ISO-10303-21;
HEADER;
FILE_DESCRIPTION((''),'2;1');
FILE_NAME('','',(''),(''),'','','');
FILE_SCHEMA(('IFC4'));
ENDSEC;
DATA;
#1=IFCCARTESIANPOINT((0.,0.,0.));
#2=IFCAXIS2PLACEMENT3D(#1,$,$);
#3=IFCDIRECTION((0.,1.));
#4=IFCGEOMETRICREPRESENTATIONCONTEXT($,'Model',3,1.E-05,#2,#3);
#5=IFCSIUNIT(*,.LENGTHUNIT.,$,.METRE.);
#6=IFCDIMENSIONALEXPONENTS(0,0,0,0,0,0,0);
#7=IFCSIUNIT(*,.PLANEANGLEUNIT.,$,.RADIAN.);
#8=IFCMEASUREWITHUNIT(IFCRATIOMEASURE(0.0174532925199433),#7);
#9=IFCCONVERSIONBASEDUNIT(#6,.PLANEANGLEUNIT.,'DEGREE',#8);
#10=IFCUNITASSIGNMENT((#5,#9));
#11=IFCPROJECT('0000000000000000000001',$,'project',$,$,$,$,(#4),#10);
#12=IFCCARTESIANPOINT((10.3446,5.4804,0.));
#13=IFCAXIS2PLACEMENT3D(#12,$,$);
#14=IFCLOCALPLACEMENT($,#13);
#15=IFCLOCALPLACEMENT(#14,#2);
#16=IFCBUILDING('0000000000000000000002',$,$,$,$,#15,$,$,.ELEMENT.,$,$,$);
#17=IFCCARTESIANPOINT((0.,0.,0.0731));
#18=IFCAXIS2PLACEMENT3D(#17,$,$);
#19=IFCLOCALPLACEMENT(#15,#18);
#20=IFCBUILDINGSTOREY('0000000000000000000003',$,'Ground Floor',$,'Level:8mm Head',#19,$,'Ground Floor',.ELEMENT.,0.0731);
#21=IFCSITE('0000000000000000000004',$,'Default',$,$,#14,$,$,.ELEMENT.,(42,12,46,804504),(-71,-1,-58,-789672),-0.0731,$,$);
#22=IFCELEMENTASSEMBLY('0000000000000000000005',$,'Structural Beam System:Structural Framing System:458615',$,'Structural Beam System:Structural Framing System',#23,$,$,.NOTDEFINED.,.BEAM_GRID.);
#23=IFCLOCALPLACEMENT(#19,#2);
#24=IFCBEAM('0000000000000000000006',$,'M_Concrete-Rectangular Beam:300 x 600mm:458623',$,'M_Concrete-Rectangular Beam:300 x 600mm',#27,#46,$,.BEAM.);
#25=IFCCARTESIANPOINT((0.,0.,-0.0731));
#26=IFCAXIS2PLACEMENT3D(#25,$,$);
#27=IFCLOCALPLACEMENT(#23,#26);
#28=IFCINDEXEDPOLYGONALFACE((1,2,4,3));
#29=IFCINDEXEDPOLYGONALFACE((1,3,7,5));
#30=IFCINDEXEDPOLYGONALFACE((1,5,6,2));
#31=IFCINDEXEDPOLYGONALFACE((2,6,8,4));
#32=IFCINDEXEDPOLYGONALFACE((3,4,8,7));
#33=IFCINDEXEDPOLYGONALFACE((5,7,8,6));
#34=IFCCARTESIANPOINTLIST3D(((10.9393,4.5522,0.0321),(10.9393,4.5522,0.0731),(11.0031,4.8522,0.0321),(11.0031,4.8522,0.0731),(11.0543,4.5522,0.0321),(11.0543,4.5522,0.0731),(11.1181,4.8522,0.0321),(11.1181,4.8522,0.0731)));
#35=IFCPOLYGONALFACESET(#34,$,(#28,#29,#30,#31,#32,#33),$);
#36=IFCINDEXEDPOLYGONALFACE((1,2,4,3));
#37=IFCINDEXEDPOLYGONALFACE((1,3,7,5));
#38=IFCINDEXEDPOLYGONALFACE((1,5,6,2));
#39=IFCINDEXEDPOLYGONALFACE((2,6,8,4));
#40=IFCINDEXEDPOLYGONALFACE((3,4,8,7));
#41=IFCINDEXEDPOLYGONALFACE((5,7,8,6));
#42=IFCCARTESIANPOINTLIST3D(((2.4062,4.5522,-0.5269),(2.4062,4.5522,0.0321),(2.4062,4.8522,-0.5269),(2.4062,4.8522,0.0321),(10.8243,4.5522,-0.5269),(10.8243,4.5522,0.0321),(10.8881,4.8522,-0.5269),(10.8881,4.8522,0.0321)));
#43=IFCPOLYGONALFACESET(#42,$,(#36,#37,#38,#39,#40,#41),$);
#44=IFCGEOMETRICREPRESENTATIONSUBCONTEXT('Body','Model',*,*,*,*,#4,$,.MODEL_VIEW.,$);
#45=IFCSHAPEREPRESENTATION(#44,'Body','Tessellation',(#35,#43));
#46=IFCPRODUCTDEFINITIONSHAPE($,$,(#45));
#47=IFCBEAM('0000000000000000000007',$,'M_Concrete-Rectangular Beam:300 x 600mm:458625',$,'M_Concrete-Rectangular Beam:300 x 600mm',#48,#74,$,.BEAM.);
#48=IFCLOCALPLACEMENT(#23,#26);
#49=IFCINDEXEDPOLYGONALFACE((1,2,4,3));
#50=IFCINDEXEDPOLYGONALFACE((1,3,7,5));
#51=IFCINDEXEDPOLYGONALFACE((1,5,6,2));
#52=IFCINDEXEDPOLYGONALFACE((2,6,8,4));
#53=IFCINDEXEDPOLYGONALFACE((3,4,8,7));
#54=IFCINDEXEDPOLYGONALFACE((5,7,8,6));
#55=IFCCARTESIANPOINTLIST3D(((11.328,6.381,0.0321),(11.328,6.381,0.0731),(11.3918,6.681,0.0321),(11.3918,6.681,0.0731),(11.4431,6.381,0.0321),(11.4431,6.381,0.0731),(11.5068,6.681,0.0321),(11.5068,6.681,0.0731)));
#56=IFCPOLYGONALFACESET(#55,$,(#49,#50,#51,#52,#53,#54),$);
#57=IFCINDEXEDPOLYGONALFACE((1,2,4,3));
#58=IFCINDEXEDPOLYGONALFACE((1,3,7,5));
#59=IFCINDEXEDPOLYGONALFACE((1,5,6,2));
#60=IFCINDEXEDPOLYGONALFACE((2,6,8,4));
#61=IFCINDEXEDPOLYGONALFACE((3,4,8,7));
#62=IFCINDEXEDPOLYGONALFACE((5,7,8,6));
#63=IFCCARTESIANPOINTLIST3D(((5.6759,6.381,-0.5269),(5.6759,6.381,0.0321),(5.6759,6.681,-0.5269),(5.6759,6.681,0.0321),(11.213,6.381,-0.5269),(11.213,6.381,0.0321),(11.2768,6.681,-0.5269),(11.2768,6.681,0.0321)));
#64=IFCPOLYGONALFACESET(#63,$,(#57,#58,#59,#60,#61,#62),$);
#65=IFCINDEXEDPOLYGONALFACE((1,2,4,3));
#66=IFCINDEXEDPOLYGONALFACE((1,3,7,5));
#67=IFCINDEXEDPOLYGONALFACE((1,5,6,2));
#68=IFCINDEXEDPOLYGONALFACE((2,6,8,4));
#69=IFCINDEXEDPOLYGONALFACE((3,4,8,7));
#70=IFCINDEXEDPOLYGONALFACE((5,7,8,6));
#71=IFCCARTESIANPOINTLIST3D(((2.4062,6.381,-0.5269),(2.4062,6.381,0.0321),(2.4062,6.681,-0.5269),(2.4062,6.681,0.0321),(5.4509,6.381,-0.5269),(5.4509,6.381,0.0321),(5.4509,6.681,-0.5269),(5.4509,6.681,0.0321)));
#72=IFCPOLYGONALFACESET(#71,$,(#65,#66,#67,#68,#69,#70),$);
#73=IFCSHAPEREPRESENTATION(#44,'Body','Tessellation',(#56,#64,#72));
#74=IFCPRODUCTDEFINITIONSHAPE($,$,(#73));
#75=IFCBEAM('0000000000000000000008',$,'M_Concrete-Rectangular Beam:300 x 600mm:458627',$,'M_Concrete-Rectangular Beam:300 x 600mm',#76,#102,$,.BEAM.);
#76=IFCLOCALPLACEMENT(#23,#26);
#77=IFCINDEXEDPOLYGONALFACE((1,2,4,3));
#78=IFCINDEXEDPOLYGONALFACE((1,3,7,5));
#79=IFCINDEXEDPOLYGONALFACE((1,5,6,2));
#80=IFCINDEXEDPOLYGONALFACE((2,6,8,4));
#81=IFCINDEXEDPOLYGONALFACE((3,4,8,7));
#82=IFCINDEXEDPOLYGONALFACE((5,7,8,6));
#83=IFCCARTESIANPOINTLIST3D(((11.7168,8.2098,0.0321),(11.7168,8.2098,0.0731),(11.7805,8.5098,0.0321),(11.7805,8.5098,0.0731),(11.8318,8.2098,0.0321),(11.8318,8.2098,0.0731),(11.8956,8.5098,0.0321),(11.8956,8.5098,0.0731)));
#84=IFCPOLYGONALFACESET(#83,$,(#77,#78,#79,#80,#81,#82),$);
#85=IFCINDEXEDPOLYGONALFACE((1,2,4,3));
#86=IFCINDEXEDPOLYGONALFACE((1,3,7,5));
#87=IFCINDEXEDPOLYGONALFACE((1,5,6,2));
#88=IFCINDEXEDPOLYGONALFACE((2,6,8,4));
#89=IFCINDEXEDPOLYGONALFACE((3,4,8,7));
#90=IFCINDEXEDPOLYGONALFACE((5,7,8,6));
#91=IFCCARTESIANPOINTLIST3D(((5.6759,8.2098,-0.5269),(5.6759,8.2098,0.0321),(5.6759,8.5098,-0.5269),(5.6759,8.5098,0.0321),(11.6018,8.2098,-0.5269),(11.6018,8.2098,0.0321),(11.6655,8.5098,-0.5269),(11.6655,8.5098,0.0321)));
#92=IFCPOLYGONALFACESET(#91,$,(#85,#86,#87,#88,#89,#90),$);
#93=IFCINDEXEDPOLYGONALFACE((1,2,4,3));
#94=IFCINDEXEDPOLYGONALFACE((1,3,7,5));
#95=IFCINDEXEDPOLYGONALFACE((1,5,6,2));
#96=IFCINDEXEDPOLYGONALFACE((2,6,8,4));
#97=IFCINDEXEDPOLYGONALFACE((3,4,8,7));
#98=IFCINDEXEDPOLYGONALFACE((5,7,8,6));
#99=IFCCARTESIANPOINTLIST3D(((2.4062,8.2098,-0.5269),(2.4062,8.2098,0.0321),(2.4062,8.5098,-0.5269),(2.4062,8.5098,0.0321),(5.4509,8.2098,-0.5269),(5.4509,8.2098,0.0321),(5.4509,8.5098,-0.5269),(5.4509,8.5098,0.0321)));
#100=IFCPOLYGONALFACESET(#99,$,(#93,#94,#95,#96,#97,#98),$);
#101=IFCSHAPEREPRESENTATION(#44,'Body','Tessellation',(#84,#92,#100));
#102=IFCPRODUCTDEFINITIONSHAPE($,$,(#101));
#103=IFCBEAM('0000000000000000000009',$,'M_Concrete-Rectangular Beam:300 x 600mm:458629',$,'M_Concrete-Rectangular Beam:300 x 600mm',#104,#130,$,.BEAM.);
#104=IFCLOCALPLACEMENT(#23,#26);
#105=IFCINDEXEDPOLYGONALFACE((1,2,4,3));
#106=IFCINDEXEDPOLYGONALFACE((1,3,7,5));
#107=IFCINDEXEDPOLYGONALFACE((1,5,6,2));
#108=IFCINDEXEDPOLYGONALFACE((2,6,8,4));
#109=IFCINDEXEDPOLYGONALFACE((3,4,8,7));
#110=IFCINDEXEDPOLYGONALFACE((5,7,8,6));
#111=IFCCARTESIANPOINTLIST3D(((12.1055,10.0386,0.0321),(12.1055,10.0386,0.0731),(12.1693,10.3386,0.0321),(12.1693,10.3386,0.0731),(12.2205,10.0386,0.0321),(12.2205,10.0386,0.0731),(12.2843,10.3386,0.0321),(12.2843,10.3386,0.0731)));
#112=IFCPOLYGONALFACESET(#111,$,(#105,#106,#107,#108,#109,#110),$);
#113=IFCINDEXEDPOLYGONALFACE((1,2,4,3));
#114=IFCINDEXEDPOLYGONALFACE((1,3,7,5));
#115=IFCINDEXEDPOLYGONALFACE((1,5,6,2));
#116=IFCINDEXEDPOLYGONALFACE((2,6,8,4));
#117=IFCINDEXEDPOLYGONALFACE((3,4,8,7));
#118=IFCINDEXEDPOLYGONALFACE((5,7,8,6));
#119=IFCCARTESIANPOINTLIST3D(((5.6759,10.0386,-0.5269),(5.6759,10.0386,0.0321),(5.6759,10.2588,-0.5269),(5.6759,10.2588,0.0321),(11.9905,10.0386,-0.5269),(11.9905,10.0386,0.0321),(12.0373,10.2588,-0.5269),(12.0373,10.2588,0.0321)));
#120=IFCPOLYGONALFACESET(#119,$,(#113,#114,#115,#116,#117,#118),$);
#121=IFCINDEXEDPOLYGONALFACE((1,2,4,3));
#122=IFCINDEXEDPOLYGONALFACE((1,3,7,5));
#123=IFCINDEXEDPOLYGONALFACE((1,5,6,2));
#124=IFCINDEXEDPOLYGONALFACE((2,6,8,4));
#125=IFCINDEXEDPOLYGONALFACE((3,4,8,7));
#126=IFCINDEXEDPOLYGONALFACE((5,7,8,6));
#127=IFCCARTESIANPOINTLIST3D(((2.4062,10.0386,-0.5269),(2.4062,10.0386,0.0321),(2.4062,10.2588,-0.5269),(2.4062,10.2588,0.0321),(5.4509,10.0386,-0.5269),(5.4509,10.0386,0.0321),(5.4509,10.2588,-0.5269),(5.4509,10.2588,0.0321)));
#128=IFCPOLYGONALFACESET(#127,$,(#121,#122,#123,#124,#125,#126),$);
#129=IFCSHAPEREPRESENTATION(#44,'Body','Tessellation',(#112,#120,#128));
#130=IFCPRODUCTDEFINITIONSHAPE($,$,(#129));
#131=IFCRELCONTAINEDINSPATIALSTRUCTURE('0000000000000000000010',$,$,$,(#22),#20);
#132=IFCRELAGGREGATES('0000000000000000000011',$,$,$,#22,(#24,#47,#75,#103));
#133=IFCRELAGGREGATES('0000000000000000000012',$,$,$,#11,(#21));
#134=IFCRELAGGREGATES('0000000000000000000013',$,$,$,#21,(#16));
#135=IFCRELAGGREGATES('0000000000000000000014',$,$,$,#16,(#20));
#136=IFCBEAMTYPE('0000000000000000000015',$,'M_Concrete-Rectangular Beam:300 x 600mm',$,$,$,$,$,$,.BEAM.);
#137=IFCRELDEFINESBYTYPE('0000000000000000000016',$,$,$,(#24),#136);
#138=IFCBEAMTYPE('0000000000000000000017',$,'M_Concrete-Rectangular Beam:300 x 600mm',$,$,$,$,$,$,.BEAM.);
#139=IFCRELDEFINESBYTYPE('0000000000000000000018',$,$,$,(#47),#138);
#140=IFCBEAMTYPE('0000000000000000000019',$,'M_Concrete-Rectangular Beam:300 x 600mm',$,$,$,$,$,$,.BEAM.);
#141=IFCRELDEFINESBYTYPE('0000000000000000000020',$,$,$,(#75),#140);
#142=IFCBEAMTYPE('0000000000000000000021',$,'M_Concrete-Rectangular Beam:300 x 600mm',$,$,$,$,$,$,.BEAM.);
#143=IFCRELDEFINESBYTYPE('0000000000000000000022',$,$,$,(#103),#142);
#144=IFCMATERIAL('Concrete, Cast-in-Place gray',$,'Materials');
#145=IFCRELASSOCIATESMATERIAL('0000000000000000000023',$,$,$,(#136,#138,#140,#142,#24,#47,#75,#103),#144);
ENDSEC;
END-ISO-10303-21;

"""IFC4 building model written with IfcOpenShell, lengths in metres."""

from ifc_helpers import new_model, entity, si_unit, converted_unit, direction, frame, frame_2d, origin, place, context, subcontext, project, spatial, rectangle, extrude, clip, halfspace, source, transform, mapped, material, material_profile, profile_set, profile_usage, type_object, type_shapes, element, aggregate, save


model = new_model("IFC4")

# Units and contexts
model_context = context("Model", 3, precision=1e-05, world=origin(), true_north=direction((0.0, 1.0)))
body_context = subcontext(model_context, "Body", "Model", "MODEL_VIEW")
ifc_project = project(units=[si_unit("LENGTHUNIT", "METRE"), converted_unit("PLANEANGLEUNIT", "DEGREE", entity("IfcRatioMeasure", 0.0174532925199433), si_unit("PLANEANGLEUNIT", "RADIAN"), dimensions=[0, 0, 0, 0, 0, 0, 0])], contexts=[model_context])

# Site, building, storey
site_placement = place(None, frame((10.3446, 5.4804, 0.0)))
site = spatial("IfcSite", under=ifc_project, at=site_placement, Name="Default", CompositionType="ELEMENT", RefLatitude=(42, 12, 46, 804504), RefLongitude=(-71, -1, -58, -789672), RefElevation=-0.0731)
building_placement = place(site_placement, origin())
building = spatial("IfcBuilding", under=site, at=building_placement, CompositionType="ELEMENT")
storey_placement = place(building_placement, frame((0.0, 0.0, 0.0731)))
storey = spatial("IfcBuildingStorey", under=building, at=storey_placement, Name="Ground Floor", ObjectType="Level:8mm Head", LongName="Ground Floor", CompositionType="ELEMENT", Elevation=0.0731)

# Element assembly, beams
ifc_material_1 = material(Name="Concrete, Cast-in-Place gray", Category="Materials")
ifc_material_profile = material_profile(ifc_material_1, rectangle(XDim=0.559, YDim=0.3, at=frame_2d((0.0, 0.0), x_axis=(1.0, 0.0))), Name="300 x 600mm")
ifc_profile_set = profile_set([ifc_material_profile], Name="300 x 600mm")
assembly_1_placement = place(storey_placement, origin())
assembly_1 = element("IfcElementAssembly", 1, at=assembly_1_placement, inside=storey, Name="Structural Beam System:Structural Framing System:458615", ObjectType="Structural Beam System:Structural Framing System", AssemblyPlace="NOTDEFINED", PredefinedType="BEAM_GRID")
ifc_profile_usage_1 = profile_usage(ifc_profile_set, cardinal=8)
beam_type_1 = type_object("IfcBeamType", Name="M_Concrete-Rectangular Beam:300 x 600mm", PredefinedType="BEAM", material=ifc_profile_set)
shared_shape_1 = source(origin(), body_context, "Body", "Clipping", [
    clip(clip(extrude(rectangle(XDim=0.041, YDim=0.3, at=frame_2d((0.0, 0.0), x_axis=(1.0, 0.0))), frame((11.1181, 4.7022, 0.0526), z_axis=(-1.0, 0.0, 0.0), x_axis=(0.0, 0.0, -1.0)), (0.0, 0.0, 1.0), 0.1788), halfspace(frame((12.1762, 10.3713, 0.0321), z_axis=(-0.978148, 0.207912, 0.0), x_axis=(0.0, 0.0, 1.0)), False)), halfspace(frame((11.0427, 4.4973, 0.4439), z_axis=(0.978148, -0.207912, 0.0), x_axis=(0.207912, 0.978148, 0.0)), False)),
    clip(extrude(rectangle(XDim=0.559, YDim=0.3, at=frame_2d((0.0, 0.0), x_axis=(1.0, 0.0))), frame((10.8881, 4.7022, -0.2474), z_axis=(-1.0, 0.0, 0.0), x_axis=(0.0, 0.0, -1.0)), (0.0, 0.0, 1.0), 8.4819), halfspace(frame((8.6968, -5.457, -2.9893), z_axis=(0.978148, -0.207912, 0.0), x_axis=(-0.207912, -0.978148, 0.0)), False)),
])
type_shapes(beam_type_1, [shared_shape_1])
beam_1_placement = place(assembly_1_placement, frame((0.0, 0.0, -0.0731)))
beam_1 = element("IfcBeam", 2, at=beam_1_placement, type_object=beam_type_1, material=ifc_profile_usage_1, Name="M_Concrete-Rectangular Beam:300 x 600mm:458623", ObjectType="M_Concrete-Rectangular Beam:300 x 600mm", PredefinedType="BEAM", context=body_context, shape_type="MappedRepresentation", body=[
    mapped(shared_shape_1, transform((0.0, 0.0, 0.0), scale=1.0)),
])
ifc_profile_usage_2 = profile_usage(ifc_profile_set, cardinal=8)
beam_type_2 = type_object("IfcBeamType", Name="M_Concrete-Rectangular Beam:300 x 600mm", PredefinedType="BEAM", material=ifc_profile_set)
shared_shape_2 = source(origin(), body_context, "Body", "SweptSolid", [
    clip(clip(extrude(rectangle(XDim=0.041, YDim=0.3, at=frame_2d((0.0, 0.0), x_axis=(1.0, 0.0))), frame((11.5068, 6.531, 0.0526), z_axis=(-1.0, 0.0, 0.0), x_axis=(0.0, 0.0, -1.0)), (0.0, 0.0, 1.0), 0.1788), halfspace(frame((12.1762, 10.3713, 0.0321), z_axis=(-0.978148, 0.207912, 0.0), x_axis=(0.0, 0.0, 1.0)), False)), halfspace(frame((11.4314, 6.3261, 0.4439), z_axis=(0.978148, -0.207912, 0.0), x_axis=(0.207912, 0.978148, 0.0)), False)),
    clip(extrude(rectangle(XDim=0.559, YDim=0.3, at=frame_2d((0.0, 0.0), x_axis=(1.0, 0.0))), frame((11.2768, 6.531, -0.2474), z_axis=(-1.0, 0.0, 0.0), x_axis=(0.0, 0.0, -1.0)), (0.0, 0.0, 1.0), 5.6009), halfspace(frame((8.6968, -5.457, -2.9893), z_axis=(0.978148, -0.207912, 0.0), x_axis=(-0.207912, -0.978148, 0.0)), False)),
    extrude(rectangle(XDim=0.559, YDim=0.3, at=frame_2d((0.0, 0.0), x_axis=(1.0, 0.0))), frame((5.4509, 6.531, -0.2474), z_axis=(-1.0, 0.0, 0.0), x_axis=(0.0, 0.0, -1.0)), (0.0, 0.0, 1.0), 3.0447),
])
type_shapes(beam_type_2, [shared_shape_2])
beam_2_placement = place(assembly_1_placement, frame((0.0, 0.0, -0.0731)))
beam_2 = element("IfcBeam", 3, at=beam_2_placement, type_object=beam_type_2, material=ifc_profile_usage_2, Name="M_Concrete-Rectangular Beam:300 x 600mm:458625", ObjectType="M_Concrete-Rectangular Beam:300 x 600mm", PredefinedType="BEAM", context=body_context, shape_type="MappedRepresentation", body=[
    mapped(shared_shape_2, transform((0.0, 0.0, 0.0), scale=1.0)),
])
ifc_profile_usage_3 = profile_usage(ifc_profile_set, cardinal=8)
beam_type_3 = type_object("IfcBeamType", Name="M_Concrete-Rectangular Beam:300 x 600mm", PredefinedType="BEAM", material=ifc_profile_set)
shared_shape_3 = source(origin(), body_context, "Body", "SweptSolid", [
    clip(clip(extrude(rectangle(XDim=0.041, YDim=0.3, at=frame_2d((0.0, 0.0), x_axis=(1.0, 0.0))), frame((11.8956, 8.3598, 0.0526), z_axis=(-1.0, 0.0, 0.0), x_axis=(0.0, 0.0, -1.0)), (0.0, 0.0, 1.0), 0.1788), halfspace(frame((12.1762, 10.3713, 0.0321), z_axis=(-0.978148, 0.207912, 0.0), x_axis=(0.0, 0.0, 1.0)), False)), halfspace(frame((11.8201, 8.1549, 0.4439), z_axis=(0.978148, -0.207912, 0.0), x_axis=(0.207912, 0.978148, 0.0)), False)),
    clip(extrude(rectangle(XDim=0.559, YDim=0.3, at=frame_2d((0.0, 0.0), x_axis=(1.0, 0.0))), frame((11.6655, 8.3598, -0.2474), z_axis=(-1.0, 0.0, 0.0), x_axis=(0.0, 0.0, -1.0)), (0.0, 0.0, 1.0), 5.9896), halfspace(frame((8.6968, -5.457, -2.9893), z_axis=(0.978148, -0.207912, 0.0), x_axis=(-0.207912, -0.978148, 0.0)), False)),
    extrude(rectangle(XDim=0.559, YDim=0.3, at=frame_2d((0.0, 0.0), x_axis=(1.0, 0.0))), frame((5.4509, 8.3598, -0.2474), z_axis=(-1.0, 0.0, 0.0), x_axis=(0.0, 0.0, -1.0)), (0.0, 0.0, 1.0), 3.0447),
])
type_shapes(beam_type_3, [shared_shape_3])
beam_3_placement = place(assembly_1_placement, frame((0.0, 0.0, -0.0731)))
beam_3 = element("IfcBeam", 4, at=beam_3_placement, type_object=beam_type_3, material=ifc_profile_usage_3, Name="M_Concrete-Rectangular Beam:300 x 600mm:458627", ObjectType="M_Concrete-Rectangular Beam:300 x 600mm", PredefinedType="BEAM", context=body_context, shape_type="MappedRepresentation", body=[
    mapped(shared_shape_3, transform((0.0, 0.0, 0.0), scale=1.0)),
])
ifc_profile_usage_4 = profile_usage(ifc_profile_set, cardinal=8)
beam_type_4 = type_object("IfcBeamType", Name="M_Concrete-Rectangular Beam:300 x 600mm", PredefinedType="BEAM", material=ifc_profile_set)
shared_shape_4 = source(origin(), body_context, "Body", "SweptSolid", [
    clip(clip(extrude(rectangle(XDim=0.041, YDim=0.3, at=frame_2d((0.0, 0.0), x_axis=(1.0, 0.0))), frame((12.2843, 10.1886, 0.0526), z_axis=(-1.0, 0.0, 0.0), x_axis=(0.0, 0.0, -1.0)), (0.0, 0.0, 1.0), 0.1788), halfspace(frame((12.1762, 10.3713, 0.0321), z_axis=(-0.978148, 0.207912, 0.0), x_axis=(0.0, 0.0, 1.0)), False)), halfspace(frame((12.2089, 9.9837, 0.4439), z_axis=(0.978148, -0.207912, 0.0), x_axis=(0.207912, 0.978148, 0.0)), False)),
    clip(extrude(rectangle(XDim=0.559, YDim=0.2202, at=frame_2d((0.0, 0.0), x_axis=(1.0, 0.0))), frame((12.0373, 10.1487, -0.2474), z_axis=(-1.0, 0.0, 0.0), x_axis=(0.0, 0.0, -1.0)), (0.0, 0.0, 1.0), 6.3614), halfspace(frame((8.6968, -5.457, -2.9893), z_axis=(0.978148, -0.207912, 0.0), x_axis=(-0.207912, -0.978148, 0.0)), False)),
    extrude(rectangle(XDim=0.559, YDim=0.2202, at=frame_2d((0.0, 0.0), x_axis=(1.0, 0.0))), frame((5.4509, 10.1487, -0.2474), z_axis=(-1.0, 0.0, 0.0), x_axis=(0.0, 0.0, -1.0)), (0.0, 0.0, 1.0), 3.0447),
])
type_shapes(beam_type_4, [shared_shape_4])
beam_4_placement = place(assembly_1_placement, frame((0.0, 0.0, -0.0731)))
beam_4 = element("IfcBeam", 5, at=beam_4_placement, type_object=beam_type_4, material=ifc_profile_usage_4, Name="M_Concrete-Rectangular Beam:300 x 600mm:458629", ObjectType="M_Concrete-Rectangular Beam:300 x 600mm", PredefinedType="BEAM", context=body_context, shape_type="MappedRepresentation", body=[
    mapped(shared_shape_4, transform((0.0, 0.0, 0.0), scale=1.0)),
])
aggregate(assembly_1, [beam_1, beam_2, beam_3, beam_4])

save(model, "model.ifc")
